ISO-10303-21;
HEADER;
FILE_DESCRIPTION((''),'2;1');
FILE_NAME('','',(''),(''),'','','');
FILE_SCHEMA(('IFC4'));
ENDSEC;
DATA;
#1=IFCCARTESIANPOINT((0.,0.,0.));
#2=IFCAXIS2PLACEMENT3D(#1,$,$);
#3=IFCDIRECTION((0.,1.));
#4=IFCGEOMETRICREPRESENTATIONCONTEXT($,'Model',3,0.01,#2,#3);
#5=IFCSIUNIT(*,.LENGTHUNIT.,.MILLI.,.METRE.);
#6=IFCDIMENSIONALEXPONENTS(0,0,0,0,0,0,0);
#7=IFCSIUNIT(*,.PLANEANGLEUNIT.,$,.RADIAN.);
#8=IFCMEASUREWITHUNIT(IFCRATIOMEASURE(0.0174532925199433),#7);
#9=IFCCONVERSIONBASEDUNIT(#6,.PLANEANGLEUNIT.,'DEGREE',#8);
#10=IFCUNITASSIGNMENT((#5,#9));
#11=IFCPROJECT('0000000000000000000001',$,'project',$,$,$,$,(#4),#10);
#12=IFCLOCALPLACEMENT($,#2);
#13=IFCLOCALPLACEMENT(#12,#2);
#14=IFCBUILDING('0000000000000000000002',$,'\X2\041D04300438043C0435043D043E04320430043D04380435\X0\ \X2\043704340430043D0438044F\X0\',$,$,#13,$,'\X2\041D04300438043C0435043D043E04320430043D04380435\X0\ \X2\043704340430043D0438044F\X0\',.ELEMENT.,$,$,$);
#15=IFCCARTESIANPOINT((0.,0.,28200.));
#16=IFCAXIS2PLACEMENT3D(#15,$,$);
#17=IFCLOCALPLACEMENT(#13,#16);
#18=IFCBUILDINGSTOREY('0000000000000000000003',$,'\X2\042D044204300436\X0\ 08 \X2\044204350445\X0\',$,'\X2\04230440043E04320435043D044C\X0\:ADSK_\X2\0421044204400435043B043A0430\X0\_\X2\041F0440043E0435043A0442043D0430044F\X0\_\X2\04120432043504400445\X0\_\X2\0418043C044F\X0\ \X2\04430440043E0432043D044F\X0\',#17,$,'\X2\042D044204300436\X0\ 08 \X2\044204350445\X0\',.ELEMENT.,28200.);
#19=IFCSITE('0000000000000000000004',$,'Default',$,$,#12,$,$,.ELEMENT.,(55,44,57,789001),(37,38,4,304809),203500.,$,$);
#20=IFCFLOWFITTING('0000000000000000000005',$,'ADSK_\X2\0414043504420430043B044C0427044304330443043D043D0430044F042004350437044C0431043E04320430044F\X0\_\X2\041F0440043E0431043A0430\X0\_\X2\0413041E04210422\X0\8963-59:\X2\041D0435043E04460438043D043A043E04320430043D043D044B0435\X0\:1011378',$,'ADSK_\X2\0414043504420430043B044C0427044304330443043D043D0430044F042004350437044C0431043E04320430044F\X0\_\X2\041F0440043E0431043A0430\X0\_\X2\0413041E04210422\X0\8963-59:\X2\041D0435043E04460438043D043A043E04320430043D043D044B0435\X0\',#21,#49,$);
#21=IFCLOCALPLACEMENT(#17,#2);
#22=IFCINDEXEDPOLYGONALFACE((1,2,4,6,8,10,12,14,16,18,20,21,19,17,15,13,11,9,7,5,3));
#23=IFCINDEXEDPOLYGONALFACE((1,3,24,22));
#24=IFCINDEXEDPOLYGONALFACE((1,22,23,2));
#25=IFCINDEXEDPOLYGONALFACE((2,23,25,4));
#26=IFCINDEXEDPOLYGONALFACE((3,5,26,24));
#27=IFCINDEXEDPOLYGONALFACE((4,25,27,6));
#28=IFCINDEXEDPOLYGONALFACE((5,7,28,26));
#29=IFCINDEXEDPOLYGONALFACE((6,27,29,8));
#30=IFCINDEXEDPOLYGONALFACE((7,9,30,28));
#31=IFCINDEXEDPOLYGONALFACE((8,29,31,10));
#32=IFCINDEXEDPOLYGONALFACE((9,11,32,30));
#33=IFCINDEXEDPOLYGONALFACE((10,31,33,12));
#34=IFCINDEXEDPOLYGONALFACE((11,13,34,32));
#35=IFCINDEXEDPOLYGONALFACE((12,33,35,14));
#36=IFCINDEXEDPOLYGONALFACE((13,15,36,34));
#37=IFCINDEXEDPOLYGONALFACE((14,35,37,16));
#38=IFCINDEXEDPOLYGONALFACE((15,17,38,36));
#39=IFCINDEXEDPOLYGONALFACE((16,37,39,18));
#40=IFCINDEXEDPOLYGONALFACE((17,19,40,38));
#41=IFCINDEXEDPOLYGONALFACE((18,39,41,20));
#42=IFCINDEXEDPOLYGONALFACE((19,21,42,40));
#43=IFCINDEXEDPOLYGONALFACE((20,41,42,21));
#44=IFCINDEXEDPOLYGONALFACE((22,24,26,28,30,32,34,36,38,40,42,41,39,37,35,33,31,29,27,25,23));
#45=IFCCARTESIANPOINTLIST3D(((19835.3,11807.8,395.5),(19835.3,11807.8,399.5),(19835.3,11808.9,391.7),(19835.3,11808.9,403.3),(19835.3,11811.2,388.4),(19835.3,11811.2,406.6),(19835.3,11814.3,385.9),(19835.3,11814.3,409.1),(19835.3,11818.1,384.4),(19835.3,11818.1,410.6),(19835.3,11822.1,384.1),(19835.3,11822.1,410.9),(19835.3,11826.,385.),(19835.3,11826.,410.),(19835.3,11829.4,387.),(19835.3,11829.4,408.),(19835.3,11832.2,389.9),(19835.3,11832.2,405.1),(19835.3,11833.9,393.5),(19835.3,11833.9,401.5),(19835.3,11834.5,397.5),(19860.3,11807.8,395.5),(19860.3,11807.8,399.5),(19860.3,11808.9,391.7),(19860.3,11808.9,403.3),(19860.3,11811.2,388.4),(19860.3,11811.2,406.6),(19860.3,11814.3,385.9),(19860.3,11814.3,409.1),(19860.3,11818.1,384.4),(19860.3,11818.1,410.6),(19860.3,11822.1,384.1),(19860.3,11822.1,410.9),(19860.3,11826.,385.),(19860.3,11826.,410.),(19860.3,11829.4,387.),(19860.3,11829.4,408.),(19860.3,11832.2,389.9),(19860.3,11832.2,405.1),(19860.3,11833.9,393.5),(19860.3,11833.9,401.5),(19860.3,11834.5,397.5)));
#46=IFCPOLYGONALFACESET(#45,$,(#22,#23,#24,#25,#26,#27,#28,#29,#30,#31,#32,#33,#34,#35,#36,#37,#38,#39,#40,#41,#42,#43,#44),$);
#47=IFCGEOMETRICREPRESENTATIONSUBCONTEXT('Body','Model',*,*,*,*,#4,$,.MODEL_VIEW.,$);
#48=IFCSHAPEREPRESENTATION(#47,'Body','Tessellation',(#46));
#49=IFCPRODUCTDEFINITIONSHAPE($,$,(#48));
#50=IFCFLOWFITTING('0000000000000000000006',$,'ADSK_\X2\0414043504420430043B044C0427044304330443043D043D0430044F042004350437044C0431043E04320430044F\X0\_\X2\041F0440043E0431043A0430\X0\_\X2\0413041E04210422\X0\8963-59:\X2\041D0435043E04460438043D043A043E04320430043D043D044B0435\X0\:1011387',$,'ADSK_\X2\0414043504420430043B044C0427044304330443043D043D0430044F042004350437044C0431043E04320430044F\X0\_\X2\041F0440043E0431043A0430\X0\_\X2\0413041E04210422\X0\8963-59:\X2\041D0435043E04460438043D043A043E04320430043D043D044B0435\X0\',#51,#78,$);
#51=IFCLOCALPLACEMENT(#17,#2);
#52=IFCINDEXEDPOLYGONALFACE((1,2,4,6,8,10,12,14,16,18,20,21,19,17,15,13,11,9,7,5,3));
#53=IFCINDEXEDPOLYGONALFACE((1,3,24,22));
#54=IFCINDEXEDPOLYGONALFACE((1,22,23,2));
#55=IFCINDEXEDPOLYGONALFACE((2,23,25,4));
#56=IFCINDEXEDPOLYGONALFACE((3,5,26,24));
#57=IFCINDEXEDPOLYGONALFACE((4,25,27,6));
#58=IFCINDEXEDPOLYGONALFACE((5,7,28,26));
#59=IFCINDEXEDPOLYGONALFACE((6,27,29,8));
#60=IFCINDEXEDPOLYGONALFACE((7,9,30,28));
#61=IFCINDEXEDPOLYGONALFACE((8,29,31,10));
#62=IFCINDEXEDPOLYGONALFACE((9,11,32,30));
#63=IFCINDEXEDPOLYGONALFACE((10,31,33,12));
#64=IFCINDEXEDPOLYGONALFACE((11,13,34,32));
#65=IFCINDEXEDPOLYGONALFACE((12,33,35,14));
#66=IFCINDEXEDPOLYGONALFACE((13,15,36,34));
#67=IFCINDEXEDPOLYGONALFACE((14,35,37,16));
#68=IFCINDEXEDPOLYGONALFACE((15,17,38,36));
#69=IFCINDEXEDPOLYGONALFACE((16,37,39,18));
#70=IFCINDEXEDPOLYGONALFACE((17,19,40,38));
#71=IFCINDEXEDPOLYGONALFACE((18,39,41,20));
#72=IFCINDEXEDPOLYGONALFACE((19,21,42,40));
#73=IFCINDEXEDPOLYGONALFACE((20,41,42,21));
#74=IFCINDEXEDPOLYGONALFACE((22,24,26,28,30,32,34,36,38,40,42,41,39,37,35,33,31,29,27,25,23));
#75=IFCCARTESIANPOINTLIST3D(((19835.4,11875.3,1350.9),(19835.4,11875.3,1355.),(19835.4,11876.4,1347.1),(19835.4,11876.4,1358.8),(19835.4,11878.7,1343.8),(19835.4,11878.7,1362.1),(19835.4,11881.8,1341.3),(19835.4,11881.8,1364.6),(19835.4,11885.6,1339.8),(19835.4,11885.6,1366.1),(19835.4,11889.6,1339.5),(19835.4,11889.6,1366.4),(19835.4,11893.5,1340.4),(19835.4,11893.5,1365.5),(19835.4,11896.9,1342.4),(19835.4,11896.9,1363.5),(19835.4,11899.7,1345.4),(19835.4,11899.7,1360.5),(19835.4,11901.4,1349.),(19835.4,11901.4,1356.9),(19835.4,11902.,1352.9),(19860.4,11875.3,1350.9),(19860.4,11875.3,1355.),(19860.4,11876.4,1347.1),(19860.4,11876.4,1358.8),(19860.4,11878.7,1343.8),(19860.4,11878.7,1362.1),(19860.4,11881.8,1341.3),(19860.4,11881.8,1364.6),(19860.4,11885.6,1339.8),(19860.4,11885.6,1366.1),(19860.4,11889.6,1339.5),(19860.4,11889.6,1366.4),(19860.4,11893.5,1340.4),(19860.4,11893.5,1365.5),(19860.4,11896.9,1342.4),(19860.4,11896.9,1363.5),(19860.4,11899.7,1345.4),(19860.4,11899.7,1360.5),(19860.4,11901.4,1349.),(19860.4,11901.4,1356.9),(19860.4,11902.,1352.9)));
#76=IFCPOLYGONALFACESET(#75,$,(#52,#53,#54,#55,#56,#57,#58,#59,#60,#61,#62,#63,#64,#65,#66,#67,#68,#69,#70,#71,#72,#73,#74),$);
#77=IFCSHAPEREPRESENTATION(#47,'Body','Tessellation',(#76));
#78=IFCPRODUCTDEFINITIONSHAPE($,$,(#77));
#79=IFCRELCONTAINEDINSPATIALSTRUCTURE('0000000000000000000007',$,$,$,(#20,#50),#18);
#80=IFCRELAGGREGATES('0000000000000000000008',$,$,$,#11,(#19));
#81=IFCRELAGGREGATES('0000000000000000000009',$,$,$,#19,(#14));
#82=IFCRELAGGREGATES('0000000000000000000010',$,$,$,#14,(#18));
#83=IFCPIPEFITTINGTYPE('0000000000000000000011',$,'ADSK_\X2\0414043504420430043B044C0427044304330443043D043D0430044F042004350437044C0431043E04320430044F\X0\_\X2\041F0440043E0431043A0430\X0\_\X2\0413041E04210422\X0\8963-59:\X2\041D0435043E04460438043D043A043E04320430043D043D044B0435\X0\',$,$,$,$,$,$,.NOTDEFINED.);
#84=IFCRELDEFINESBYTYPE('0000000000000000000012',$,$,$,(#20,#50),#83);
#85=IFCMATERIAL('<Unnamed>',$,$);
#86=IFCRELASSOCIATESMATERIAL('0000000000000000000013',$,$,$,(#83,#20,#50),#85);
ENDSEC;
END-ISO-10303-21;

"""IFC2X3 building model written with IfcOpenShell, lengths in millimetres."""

from ifc_helpers import new_model, entity, si_unit, converted_unit, direction, frame, origin, origin_2d_with_axis, place, context, subcontext, project, spatial, circle, extrude, source, transform, mapped, material, type_object, type_shapes, element, save


model = new_model("IFC2X3")

# Units and contexts
model_context = context("Model", 3, precision=0.01, world=origin(), true_north=direction((0.0, 1.0)))
body_context = subcontext(model_context, "Body", "Model", "MODEL_VIEW")
ifc_project = project(units=[si_unit("LENGTHUNIT", "METRE", prefix="MILLI"), converted_unit("PLANEANGLEUNIT", "DEGREE", entity("IfcRatioMeasure", 0.0174532925199433), si_unit("PLANEANGLEUNIT", "RADIAN"), dimensions=[0, 0, 0, 0, 0, 0, 0])], contexts=[model_context])

# Site, building, storey
site_placement = place(None, origin())
site = spatial("IfcSite", under=ifc_project, at=site_placement, Name="Default", CompositionType="ELEMENT", RefLatitude=(55, 44, 57, 789001), RefLongitude=(37, 38, 4, 304809), RefElevation=203500.0)
building_placement = place(site_placement, origin())
building = spatial("IfcBuilding", under=site, at=building_placement, Name="Наименование здания", LongName="Наименование здания", CompositionType="ELEMENT")
storey_placement = place(building_placement, frame((0.0, 0.0, 28200.0)))
storey = spatial("IfcBuildingStorey", under=building, at=storey_placement, Name="Этаж 08 тех", ObjectType="Уровень:ADSK_Стрелка_Проектная_Вверх_Имя уровня", LongName="Этаж 08 тех", CompositionType="ELEMENT", Elevation=28200.0)

# Shared definitions
ifc_material = material(Name="<Unnamed>")

# Flow fittings
pipe_fitting_type_1 = type_object("IfcPipeFittingType", Name="ADSK_ДетальЧугуннаяРезьбовая_Пробка_ГОСТ8963-59:Неоцинкованные", PredefinedType="NOTDEFINED", material=ifc_material)
shared_shape_1 = source(origin(), body_context, "Body", "SweptSolid", [
    extrude(circle(Radius=13.4, at=origin_2d_with_axis()), frame((0.0, 0.0, 0.0), z_axis=(1.0, 0.0, 0.0), x_axis=(0.0, 1.0, 0.0)), (0.0, 0.0, 1.0), 25.0),
])
type_shapes(pipe_fitting_type_1, [shared_shape_1])
for number, where, name in (
    (1, (19835.3, 11821.1, 397.5), "ADSK_ДетальЧугуннаяРезьбовая_Пробка_ГОСТ8963-59:Неоцинкованные:1011378"),
    (2, (19835.4, 11888.6, 1353.0), "ADSK_ДетальЧугуннаяРезьбовая_Пробка_ГОСТ8963-59:Неоцинкованные:1011387"),
):
    element("IfcFlowFitting", number, at=place(storey_placement, frame(where)), inside=storey, type_object=pipe_fitting_type_1, material=ifc_material, Name=name, ObjectType="ADSK_ДетальЧугуннаяРезьбовая_Пробка_ГОСТ8963-59:Неоцинкованные", context=body_context, shape_type="MappedRepresentation", body=[
        mapped(shared_shape_1, transform((0.0, 0.0, 0.0), scale=1.0)),
    ])

save(model, "model.ifc")
